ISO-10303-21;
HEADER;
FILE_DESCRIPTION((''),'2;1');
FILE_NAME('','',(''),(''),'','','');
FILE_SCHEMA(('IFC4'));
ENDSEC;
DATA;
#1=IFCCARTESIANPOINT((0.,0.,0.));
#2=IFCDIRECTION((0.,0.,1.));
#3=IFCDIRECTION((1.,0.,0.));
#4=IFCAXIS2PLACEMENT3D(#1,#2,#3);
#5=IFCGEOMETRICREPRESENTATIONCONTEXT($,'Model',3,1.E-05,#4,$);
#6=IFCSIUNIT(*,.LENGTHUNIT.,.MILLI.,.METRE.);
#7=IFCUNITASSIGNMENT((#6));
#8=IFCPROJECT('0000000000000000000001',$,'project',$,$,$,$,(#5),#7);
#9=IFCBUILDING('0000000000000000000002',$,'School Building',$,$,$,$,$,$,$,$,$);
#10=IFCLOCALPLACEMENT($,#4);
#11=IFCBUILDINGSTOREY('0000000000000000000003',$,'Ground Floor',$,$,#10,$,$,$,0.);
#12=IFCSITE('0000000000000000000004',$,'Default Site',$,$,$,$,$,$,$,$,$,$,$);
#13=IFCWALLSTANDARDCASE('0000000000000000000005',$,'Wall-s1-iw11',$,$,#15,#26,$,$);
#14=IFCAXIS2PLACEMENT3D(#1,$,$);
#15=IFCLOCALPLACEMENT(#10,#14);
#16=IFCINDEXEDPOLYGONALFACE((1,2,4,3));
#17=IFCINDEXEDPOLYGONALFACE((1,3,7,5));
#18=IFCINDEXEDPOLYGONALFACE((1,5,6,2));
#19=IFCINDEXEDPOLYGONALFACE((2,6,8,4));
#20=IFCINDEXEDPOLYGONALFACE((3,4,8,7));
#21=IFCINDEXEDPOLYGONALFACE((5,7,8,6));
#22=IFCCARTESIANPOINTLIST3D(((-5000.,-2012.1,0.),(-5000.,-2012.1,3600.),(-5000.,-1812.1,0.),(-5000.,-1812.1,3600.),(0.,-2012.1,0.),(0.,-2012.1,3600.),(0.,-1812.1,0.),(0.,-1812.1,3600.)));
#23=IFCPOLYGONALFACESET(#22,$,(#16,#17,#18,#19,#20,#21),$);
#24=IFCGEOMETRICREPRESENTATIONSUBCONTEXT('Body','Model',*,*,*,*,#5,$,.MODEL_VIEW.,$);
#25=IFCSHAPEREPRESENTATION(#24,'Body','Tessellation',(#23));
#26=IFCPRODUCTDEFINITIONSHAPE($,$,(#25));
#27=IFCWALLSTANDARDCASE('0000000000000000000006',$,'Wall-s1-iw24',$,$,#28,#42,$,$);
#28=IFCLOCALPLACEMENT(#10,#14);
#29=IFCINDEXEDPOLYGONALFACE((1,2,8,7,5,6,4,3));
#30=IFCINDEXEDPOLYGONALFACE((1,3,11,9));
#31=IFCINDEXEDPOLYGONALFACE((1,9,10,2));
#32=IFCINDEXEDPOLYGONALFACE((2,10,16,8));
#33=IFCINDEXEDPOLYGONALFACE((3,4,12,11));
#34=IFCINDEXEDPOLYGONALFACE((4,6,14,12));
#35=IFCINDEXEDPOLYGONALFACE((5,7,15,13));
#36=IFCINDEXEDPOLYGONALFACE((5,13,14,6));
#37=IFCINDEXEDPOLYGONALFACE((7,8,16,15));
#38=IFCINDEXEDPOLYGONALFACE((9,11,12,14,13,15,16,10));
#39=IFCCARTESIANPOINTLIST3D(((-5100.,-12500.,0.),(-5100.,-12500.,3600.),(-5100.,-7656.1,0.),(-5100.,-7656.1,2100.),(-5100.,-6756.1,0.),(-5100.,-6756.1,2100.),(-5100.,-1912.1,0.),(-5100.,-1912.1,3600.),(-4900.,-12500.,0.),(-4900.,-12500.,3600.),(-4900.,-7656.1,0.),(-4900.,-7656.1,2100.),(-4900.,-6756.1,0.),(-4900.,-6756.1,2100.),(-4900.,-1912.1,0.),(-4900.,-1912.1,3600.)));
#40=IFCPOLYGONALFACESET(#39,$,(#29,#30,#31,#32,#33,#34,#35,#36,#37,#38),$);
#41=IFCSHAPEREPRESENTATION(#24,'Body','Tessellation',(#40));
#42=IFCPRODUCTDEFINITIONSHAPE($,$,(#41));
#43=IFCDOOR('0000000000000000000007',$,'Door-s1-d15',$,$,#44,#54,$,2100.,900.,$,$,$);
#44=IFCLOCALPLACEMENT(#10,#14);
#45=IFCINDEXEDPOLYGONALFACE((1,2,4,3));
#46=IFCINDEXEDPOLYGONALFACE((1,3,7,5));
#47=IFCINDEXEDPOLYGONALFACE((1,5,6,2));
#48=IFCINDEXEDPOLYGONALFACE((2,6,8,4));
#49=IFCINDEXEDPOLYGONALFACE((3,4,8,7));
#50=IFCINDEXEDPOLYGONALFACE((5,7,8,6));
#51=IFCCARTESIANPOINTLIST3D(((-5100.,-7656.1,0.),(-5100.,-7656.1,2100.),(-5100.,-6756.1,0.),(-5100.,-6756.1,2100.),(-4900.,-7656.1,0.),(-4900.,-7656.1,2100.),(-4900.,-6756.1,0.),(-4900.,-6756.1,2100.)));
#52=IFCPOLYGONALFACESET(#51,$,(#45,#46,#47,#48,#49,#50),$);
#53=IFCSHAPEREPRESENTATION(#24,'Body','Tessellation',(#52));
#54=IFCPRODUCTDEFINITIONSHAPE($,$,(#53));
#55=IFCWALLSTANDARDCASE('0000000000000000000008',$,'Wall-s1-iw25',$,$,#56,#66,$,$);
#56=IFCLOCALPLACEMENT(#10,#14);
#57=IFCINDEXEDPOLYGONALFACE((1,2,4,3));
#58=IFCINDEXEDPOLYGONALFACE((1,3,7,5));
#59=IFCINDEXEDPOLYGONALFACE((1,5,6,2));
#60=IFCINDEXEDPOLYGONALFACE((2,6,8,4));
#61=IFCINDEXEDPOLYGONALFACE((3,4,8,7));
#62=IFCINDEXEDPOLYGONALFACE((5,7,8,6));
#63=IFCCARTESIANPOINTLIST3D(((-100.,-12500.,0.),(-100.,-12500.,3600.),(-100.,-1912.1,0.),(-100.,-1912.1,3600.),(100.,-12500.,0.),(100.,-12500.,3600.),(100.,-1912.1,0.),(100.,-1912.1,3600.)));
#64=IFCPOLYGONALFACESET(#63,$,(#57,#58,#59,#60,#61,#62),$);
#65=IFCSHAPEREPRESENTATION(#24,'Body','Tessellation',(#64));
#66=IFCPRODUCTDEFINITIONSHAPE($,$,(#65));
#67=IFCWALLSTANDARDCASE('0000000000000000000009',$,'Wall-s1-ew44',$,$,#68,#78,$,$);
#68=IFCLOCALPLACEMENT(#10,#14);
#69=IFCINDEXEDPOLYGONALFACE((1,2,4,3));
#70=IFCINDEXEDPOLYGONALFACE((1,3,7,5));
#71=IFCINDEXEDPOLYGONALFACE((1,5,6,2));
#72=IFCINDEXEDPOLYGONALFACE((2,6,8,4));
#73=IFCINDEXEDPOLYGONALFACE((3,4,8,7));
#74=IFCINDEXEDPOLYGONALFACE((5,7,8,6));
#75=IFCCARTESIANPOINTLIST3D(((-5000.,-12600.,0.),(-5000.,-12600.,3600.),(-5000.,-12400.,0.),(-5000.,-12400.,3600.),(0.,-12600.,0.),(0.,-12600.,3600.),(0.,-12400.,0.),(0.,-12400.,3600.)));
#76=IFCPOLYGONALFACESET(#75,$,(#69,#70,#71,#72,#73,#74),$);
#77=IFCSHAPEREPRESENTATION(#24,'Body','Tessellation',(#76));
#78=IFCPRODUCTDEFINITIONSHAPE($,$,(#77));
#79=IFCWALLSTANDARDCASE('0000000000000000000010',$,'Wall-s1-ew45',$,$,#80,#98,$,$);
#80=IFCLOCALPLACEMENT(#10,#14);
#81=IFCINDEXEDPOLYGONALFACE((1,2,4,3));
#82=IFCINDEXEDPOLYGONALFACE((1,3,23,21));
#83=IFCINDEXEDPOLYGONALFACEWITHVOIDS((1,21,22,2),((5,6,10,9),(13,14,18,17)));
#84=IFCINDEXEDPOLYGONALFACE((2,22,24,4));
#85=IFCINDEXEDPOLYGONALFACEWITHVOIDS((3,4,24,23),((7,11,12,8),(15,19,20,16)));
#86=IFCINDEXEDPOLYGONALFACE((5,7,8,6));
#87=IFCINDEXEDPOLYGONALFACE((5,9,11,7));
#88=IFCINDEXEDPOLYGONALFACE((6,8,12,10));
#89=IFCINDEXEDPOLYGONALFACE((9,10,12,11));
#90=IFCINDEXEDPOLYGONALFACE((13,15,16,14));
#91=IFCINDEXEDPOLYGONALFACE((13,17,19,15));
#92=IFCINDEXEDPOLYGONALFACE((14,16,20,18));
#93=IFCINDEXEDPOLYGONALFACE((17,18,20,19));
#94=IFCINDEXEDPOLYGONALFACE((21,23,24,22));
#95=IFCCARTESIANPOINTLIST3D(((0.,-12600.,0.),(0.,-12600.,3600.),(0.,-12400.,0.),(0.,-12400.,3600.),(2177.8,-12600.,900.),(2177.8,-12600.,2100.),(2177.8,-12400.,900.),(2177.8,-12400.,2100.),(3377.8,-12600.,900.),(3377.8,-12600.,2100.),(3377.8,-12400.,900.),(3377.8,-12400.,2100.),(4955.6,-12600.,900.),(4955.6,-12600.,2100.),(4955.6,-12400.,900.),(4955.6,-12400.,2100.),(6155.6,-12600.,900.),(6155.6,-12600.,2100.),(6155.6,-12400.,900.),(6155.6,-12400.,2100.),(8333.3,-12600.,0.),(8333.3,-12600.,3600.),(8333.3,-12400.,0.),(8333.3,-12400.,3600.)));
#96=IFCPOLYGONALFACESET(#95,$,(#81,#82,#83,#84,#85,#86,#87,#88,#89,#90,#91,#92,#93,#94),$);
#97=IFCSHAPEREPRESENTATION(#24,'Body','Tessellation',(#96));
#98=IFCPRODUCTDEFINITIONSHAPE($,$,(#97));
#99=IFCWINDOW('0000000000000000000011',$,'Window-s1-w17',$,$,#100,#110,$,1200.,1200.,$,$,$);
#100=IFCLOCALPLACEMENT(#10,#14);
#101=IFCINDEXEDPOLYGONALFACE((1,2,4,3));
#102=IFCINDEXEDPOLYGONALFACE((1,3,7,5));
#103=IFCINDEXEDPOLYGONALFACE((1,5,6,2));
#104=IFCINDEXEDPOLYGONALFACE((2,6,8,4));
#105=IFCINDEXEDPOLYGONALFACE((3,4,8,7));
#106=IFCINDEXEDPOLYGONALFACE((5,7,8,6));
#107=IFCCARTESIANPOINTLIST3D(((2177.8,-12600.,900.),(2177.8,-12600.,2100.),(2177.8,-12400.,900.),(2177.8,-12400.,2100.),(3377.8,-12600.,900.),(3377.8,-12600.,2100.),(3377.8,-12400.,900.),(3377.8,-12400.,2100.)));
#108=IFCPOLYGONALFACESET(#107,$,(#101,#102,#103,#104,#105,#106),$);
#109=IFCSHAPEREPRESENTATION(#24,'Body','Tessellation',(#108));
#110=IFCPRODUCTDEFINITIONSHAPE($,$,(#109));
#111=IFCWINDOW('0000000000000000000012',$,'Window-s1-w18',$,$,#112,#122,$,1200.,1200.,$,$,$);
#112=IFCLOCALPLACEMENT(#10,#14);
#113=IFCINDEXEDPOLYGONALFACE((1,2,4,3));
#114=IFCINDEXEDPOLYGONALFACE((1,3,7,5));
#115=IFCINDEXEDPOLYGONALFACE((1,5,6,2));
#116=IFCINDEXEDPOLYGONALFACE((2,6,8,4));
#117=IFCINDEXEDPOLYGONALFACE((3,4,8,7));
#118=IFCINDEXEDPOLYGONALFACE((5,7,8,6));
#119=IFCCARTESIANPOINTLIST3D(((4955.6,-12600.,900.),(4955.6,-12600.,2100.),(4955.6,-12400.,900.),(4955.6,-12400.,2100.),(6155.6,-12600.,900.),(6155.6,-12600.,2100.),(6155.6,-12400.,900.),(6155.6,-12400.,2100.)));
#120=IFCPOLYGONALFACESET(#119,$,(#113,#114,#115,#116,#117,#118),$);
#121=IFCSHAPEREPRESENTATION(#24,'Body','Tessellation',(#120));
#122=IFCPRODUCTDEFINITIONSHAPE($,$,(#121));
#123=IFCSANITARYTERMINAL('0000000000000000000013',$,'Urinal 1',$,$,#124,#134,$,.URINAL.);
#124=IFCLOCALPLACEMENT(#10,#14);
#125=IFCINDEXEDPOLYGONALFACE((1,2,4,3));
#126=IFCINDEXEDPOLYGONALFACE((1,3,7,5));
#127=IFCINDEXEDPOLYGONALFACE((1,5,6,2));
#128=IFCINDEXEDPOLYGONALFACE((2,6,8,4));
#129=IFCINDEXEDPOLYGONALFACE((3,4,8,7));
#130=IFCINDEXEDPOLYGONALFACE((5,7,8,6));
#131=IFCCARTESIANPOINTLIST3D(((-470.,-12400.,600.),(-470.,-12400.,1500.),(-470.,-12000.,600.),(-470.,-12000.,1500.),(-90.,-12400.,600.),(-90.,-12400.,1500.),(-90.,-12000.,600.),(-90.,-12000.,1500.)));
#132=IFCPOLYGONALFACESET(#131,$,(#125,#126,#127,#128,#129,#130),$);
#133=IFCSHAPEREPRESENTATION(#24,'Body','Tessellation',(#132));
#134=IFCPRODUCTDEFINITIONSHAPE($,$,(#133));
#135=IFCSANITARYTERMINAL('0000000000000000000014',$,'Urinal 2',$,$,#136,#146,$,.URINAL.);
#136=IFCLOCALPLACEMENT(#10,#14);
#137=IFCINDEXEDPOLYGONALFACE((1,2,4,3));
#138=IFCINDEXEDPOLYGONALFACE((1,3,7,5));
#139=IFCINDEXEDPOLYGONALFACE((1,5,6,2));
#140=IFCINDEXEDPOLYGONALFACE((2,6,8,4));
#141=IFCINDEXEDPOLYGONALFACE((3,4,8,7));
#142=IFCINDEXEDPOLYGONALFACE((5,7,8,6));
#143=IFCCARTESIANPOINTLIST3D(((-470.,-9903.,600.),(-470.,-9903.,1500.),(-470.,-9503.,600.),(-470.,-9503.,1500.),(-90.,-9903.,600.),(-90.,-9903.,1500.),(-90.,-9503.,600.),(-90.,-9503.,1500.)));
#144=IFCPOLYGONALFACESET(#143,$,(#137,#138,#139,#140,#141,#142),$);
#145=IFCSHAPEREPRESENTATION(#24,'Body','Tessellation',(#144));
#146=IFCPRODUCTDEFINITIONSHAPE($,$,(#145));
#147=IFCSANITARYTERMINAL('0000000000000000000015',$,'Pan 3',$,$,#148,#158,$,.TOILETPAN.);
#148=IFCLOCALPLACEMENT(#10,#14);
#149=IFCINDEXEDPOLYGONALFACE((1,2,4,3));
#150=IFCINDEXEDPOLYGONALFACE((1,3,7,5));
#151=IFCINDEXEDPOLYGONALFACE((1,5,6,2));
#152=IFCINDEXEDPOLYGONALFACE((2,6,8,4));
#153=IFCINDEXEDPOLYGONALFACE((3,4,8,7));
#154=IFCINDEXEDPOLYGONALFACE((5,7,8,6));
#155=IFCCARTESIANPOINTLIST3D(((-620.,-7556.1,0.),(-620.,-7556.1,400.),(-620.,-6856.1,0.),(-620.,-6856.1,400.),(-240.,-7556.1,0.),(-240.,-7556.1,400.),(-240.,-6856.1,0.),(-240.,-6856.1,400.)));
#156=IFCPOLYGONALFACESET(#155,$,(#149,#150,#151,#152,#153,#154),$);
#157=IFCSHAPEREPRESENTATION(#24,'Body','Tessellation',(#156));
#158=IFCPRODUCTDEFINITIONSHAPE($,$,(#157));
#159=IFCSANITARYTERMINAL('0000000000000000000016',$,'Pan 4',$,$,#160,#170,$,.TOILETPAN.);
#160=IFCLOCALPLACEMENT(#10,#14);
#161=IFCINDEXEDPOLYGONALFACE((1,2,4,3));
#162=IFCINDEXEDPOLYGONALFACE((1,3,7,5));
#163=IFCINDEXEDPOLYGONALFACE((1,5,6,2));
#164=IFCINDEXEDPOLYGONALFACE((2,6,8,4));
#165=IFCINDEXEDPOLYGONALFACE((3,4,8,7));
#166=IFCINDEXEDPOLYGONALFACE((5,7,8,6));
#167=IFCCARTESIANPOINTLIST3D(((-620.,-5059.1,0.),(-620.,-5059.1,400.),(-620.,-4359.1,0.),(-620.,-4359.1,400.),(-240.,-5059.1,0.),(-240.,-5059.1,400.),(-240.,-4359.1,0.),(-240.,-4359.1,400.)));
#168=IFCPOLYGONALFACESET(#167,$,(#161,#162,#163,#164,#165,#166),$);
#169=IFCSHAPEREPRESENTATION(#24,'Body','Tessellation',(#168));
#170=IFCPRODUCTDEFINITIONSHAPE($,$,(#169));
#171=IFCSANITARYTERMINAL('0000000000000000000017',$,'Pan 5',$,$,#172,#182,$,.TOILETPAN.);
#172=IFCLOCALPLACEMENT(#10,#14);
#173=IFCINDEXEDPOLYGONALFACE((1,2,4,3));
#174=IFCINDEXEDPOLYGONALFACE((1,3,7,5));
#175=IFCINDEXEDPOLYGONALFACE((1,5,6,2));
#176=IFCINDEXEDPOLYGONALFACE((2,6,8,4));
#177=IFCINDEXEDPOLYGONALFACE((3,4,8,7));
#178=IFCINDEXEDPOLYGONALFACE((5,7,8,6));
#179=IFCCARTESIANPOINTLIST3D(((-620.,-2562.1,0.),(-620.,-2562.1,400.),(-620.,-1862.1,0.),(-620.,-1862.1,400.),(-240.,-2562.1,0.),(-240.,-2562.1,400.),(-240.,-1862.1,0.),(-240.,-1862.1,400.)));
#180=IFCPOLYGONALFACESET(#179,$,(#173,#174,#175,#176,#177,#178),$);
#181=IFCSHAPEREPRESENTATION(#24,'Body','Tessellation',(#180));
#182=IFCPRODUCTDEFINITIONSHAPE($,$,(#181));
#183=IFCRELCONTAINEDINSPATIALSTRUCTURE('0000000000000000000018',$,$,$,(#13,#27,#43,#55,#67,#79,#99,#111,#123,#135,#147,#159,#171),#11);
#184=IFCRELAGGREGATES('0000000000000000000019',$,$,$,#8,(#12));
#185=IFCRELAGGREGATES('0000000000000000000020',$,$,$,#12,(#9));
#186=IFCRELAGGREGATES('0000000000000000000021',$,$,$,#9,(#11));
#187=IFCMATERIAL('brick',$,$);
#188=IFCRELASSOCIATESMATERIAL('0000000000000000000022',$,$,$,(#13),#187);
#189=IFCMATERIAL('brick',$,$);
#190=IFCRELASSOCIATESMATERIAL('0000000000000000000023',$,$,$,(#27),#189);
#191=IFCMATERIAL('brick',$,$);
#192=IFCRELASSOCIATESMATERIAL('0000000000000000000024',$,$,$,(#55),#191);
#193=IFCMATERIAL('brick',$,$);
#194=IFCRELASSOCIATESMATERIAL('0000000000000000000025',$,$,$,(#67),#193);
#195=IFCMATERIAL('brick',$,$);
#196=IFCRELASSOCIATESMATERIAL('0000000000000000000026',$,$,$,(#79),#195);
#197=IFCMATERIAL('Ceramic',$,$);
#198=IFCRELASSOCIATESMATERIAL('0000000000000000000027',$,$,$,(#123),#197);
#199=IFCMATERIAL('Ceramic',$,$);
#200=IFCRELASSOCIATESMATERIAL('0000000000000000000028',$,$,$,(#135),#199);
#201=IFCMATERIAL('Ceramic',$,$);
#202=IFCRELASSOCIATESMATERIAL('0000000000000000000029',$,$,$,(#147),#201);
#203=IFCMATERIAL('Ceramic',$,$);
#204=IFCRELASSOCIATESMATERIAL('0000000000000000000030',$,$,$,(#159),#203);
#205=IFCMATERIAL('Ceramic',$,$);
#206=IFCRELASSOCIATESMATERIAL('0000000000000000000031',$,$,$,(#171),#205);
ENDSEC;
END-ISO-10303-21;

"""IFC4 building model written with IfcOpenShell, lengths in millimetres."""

from ifc_helpers import new_model, si_unit, frame, frame_2d, origin_with_axes, origin_2d, place, context, subcontext, project, spatial, rectangle, extrude, material, element, fill, save


model = new_model("IFC4")

# Units and contexts
model_context = context("Model", 3, precision=1e-05, world=origin_with_axes())
body_context = subcontext(model_context, "Body", "Model", "MODEL_VIEW")
ifc_project = project(units=[si_unit("LENGTHUNIT", "METRE", prefix="MILLI")], contexts=[model_context])

# Site, building, storey
site = spatial("IfcSite", under=ifc_project, Name="Default Site")
building = spatial("IfcBuilding", under=site, Name="School Building")
storey_placement = place(None, origin_with_axes())
storey = spatial("IfcBuildingStorey", under=building, at=storey_placement, Name="Ground Floor", Elevation=0.0)

# Wall
ifc_material_1 = material(Name="brick")
wall_1_placement = place(storey_placement, frame((-5000.0, -1912.1, 0.0), z_axis=(0.0, 0.0, 1.0), x_axis=(1.0, 0.0, 0.0)))
element("IfcWallStandardCase", 1, at=wall_1_placement, inside=storey, material=ifc_material_1, Name="Wall-s1-iw11", context=body_context, shape_type="SweptSolid", body=[
    extrude(rectangle(XDim=5000.0, YDim=200.0, at=frame_2d((2500.0, 0.0))), origin_with_axes(), (0.0, 0.0, 1.0), 3600.0),
])

# Wall, opening, door
ifc_material_2 = material(Name="brick")
wall_2_placement = place(storey_placement, frame((-5000.0, -12500.0, 0.0), z_axis=(0.0, 0.0, 1.0), x_axis=(0.0, 1.0, 0.0)))
wall_2 = element("IfcWallStandardCase", 2, at=wall_2_placement, inside=storey, material=ifc_material_2, Name="Wall-s1-iw24", context=body_context, shape_type="SweptSolid", body=[
    extrude(rectangle(XDim=10587.9, YDim=200.0, at=frame_2d((5293.9, 0.0))), origin_with_axes(), (0.0, 0.0, 1.0), 3600.0),
])
opening_1_placement = place(wall_2_placement, frame((4843.9, 0.0, 0.0), z_axis=(0.0, 0.0, 1.0), x_axis=(1.0, 0.0, 0.0)))
opening_1 = element("IfcOpeningElement", 3, at=opening_1_placement, cuts=wall_2, context=body_context, shape_type="SweptSolid", body=[
    extrude(rectangle(XDim=900.0, YDim=400.0, at=frame_2d((450.0, 0.0))), origin_with_axes(), (0.0, 0.0, 1.0), 2100.0),
])
door_placement = place(storey_placement, frame((-5000.0, -7656.1, 0.0), z_axis=(0.0, 0.0, 1.0), x_axis=(0.0, 1.0, 0.0)))
door = element("IfcDoor", 4, at=door_placement, inside=storey, Name="Door-s1-d15", OverallHeight=2100.0, OverallWidth=900.0, context=body_context, shape_type="SweptSolid", body=[
    extrude(rectangle(XDim=900.0, YDim=200.0, at=frame_2d((450.0, 0.0))), origin_with_axes(), (0.0, 0.0, 1.0), 2100.0),
])
fill(opening_1, door)

# Walls
ifc_material_3 = material(Name="brick")
wall_3_placement = place(storey_placement, frame((0.0, -12500.0, 0.0), z_axis=(0.0, 0.0, 1.0), x_axis=(0.0, 1.0, 0.0)))
element("IfcWallStandardCase", 5, at=wall_3_placement, inside=storey, material=ifc_material_3, Name="Wall-s1-iw25", context=body_context, shape_type="SweptSolid", body=[
    extrude(rectangle(XDim=10587.9, YDim=200.0, at=frame_2d((5293.9, 0.0))), origin_with_axes(), (0.0, 0.0, 1.0), 3600.0),
])
ifc_material_4 = material(Name="brick")
wall_4_placement = place(storey_placement, frame((-5000.0, -12500.0, 0.0), z_axis=(0.0, 0.0, 1.0), x_axis=(1.0, 0.0, 0.0)))
element("IfcWallStandardCase", 6, at=wall_4_placement, inside=storey, material=ifc_material_4, Name="Wall-s1-ew44", context=body_context, shape_type="SweptSolid", body=[
    extrude(rectangle(XDim=5000.0, YDim=200.0, at=frame_2d((2500.0, 0.0))), origin_with_axes(), (0.0, 0.0, 1.0), 3600.0),
])

# Wall, openings, windows
ifc_material_5 = material(Name="brick")
wall_5_placement = place(storey_placement, frame((0.0, -12500.0, 0.0), z_axis=(0.0, 0.0, 1.0), x_axis=(1.0, 0.0, 0.0)))
wall_5 = element("IfcWallStandardCase", 7, at=wall_5_placement, inside=storey, material=ifc_material_5, Name="Wall-s1-ew45", context=body_context, shape_type="SweptSolid", body=[
    extrude(rectangle(XDim=8333.3, YDim=200.0, at=frame_2d((4166.7, 0.0))), origin_with_axes(), (0.0, 0.0, 1.0), 3600.0),
])
opening_2_placement = place(wall_5_placement, frame((2177.8, 0.0, 900.0), z_axis=(0.0, 0.0, 1.0), x_axis=(1.0, 0.0, 0.0)))
opening_2 = element("IfcOpeningElement", 8, at=opening_2_placement, cuts=wall_5, context=body_context, shape_type="SweptSolid", body=[
    extrude(rectangle(XDim=1200.0, YDim=400.0, at=frame_2d((600.0, 0.0))), origin_with_axes(), (0.0, 0.0, 1.0), 1200.0),
])
opening_3_placement = place(wall_5_placement, frame((4955.6, 0.0, 900.0), z_axis=(0.0, 0.0, 1.0), x_axis=(1.0, 0.0, 0.0)))
opening_3 = element("IfcOpeningElement", 9, at=opening_3_placement, cuts=wall_5, context=body_context, shape_type="SweptSolid", body=[
    extrude(rectangle(XDim=1200.0, YDim=400.0, at=frame_2d((600.0, 0.0))), origin_with_axes(), (0.0, 0.0, 1.0), 1200.0),
])
window_1_placement = place(storey_placement, frame((2177.8, -12500.0, 900.0), z_axis=(0.0, 0.0, 1.0), x_axis=(1.0, 0.0, 0.0)))
window_1 = element("IfcWindow", 10, at=window_1_placement, inside=storey, Name="Window-s1-w17", OverallHeight=1200.0, OverallWidth=1200.0, context=body_context, shape_type="SweptSolid", body=[
    extrude(rectangle(XDim=1200.0, YDim=200.0, at=frame_2d((600.0, 0.0))), origin_with_axes(), (0.0, 0.0, 1.0), 1200.0),
])
fill(opening_2, window_1)
window_2_placement = place(storey_placement, frame((4955.6, -12500.0, 900.0), z_axis=(0.0, 0.0, 1.0), x_axis=(1.0, 0.0, 0.0)))
window_2 = element("IfcWindow", 11, at=window_2_placement, inside=storey, Name="Window-s1-w18", OverallHeight=1200.0, OverallWidth=1200.0, context=body_context, shape_type="SweptSolid", body=[
    extrude(rectangle(XDim=1200.0, YDim=200.0, at=frame_2d((600.0, 0.0))), origin_with_axes(), (0.0, 0.0, 1.0), 1200.0),
])
fill(opening_3, window_2)

# Sanitary terminals
ifc_material_6 = material(Name="Ceramic")
sanitary_terminal_1_placement = place(storey_placement, frame((-280.0, -12200.0, 600.0), z_axis=(0.0, 0.0, 1.0), x_axis=(0.0, 1.0, 0.0)))
element("IfcSanitaryTerminal", 12, at=sanitary_terminal_1_placement, inside=storey, material=ifc_material_6, Name="Urinal 1", PredefinedType="URINAL", context=body_context, shape_type="SweptSolid", body=[
    extrude(rectangle(XDim=400.0, YDim=380.0, at=origin_2d()), origin_with_axes(), (0.0, 0.0, 1.0), 900.0),
])
ifc_material_7 = material(Name="Ceramic")
sanitary_terminal_2_placement = place(storey_placement, frame((-280.0, -9703.0, 600.0), z_axis=(0.0, 0.0, 1.0), x_axis=(0.0, 1.0, 0.0)))
element("IfcSanitaryTerminal", 13, at=sanitary_terminal_2_placement, inside=storey, material=ifc_material_7, Name="Urinal 2", PredefinedType="URINAL", context=body_context, shape_type="SweptSolid", body=[
    extrude(rectangle(XDim=400.0, YDim=380.0, at=origin_2d()), origin_with_axes(), (0.0, 0.0, 1.0), 900.0),
])
ifc_material_8 = material(Name="Ceramic")
sanitary_terminal_3_placement = place(storey_placement, frame((-430.0, -7206.1, 0.0), z_axis=(0.0, 0.0, 1.0), x_axis=(0.0, 1.0, 0.0)))
element("IfcSanitaryTerminal", 14, at=sanitary_terminal_3_placement, inside=storey, material=ifc_material_8, Name="Pan 3", PredefinedType="TOILETPAN", context=body_context, shape_type="SweptSolid", body=[
    extrude(rectangle(XDim=700.0, YDim=380.0, at=origin_2d()), origin_with_axes(), (0.0, 0.0, 1.0), 400.0),
])
ifc_material_9 = material(Name="Ceramic")
sanitary_terminal_4_placement = place(storey_placement, frame((-430.0, -4709.1, 0.0), z_axis=(0.0, 0.0, 1.0), x_axis=(0.0, 1.0, 0.0)))
element("IfcSanitaryTerminal", 15, at=sanitary_terminal_4_placement, inside=storey, material=ifc_material_9, Name="Pan 4", PredefinedType="TOILETPAN", context=body_context, shape_type="SweptSolid", body=[
    extrude(rectangle(XDim=700.0, YDim=380.0, at=origin_2d()), origin_with_axes(), (0.0, 0.0, 1.0), 400.0),
])
ifc_material_10 = material(Name="Ceramic")
sanitary_terminal_5_placement = place(storey_placement, frame((-430.0, -2212.1, 0.0), z_axis=(0.0, 0.0, 1.0), x_axis=(0.0, 1.0, 0.0)))
element("IfcSanitaryTerminal", 16, at=sanitary_terminal_5_placement, inside=storey, material=ifc_material_10, Name="Pan 5", PredefinedType="TOILETPAN", context=body_context, shape_type="SweptSolid", body=[
    extrude(rectangle(XDim=700.0, YDim=380.0, at=origin_2d()), origin_with_axes(), (0.0, 0.0, 1.0), 400.0),
])

save(model, "model.ifc")
